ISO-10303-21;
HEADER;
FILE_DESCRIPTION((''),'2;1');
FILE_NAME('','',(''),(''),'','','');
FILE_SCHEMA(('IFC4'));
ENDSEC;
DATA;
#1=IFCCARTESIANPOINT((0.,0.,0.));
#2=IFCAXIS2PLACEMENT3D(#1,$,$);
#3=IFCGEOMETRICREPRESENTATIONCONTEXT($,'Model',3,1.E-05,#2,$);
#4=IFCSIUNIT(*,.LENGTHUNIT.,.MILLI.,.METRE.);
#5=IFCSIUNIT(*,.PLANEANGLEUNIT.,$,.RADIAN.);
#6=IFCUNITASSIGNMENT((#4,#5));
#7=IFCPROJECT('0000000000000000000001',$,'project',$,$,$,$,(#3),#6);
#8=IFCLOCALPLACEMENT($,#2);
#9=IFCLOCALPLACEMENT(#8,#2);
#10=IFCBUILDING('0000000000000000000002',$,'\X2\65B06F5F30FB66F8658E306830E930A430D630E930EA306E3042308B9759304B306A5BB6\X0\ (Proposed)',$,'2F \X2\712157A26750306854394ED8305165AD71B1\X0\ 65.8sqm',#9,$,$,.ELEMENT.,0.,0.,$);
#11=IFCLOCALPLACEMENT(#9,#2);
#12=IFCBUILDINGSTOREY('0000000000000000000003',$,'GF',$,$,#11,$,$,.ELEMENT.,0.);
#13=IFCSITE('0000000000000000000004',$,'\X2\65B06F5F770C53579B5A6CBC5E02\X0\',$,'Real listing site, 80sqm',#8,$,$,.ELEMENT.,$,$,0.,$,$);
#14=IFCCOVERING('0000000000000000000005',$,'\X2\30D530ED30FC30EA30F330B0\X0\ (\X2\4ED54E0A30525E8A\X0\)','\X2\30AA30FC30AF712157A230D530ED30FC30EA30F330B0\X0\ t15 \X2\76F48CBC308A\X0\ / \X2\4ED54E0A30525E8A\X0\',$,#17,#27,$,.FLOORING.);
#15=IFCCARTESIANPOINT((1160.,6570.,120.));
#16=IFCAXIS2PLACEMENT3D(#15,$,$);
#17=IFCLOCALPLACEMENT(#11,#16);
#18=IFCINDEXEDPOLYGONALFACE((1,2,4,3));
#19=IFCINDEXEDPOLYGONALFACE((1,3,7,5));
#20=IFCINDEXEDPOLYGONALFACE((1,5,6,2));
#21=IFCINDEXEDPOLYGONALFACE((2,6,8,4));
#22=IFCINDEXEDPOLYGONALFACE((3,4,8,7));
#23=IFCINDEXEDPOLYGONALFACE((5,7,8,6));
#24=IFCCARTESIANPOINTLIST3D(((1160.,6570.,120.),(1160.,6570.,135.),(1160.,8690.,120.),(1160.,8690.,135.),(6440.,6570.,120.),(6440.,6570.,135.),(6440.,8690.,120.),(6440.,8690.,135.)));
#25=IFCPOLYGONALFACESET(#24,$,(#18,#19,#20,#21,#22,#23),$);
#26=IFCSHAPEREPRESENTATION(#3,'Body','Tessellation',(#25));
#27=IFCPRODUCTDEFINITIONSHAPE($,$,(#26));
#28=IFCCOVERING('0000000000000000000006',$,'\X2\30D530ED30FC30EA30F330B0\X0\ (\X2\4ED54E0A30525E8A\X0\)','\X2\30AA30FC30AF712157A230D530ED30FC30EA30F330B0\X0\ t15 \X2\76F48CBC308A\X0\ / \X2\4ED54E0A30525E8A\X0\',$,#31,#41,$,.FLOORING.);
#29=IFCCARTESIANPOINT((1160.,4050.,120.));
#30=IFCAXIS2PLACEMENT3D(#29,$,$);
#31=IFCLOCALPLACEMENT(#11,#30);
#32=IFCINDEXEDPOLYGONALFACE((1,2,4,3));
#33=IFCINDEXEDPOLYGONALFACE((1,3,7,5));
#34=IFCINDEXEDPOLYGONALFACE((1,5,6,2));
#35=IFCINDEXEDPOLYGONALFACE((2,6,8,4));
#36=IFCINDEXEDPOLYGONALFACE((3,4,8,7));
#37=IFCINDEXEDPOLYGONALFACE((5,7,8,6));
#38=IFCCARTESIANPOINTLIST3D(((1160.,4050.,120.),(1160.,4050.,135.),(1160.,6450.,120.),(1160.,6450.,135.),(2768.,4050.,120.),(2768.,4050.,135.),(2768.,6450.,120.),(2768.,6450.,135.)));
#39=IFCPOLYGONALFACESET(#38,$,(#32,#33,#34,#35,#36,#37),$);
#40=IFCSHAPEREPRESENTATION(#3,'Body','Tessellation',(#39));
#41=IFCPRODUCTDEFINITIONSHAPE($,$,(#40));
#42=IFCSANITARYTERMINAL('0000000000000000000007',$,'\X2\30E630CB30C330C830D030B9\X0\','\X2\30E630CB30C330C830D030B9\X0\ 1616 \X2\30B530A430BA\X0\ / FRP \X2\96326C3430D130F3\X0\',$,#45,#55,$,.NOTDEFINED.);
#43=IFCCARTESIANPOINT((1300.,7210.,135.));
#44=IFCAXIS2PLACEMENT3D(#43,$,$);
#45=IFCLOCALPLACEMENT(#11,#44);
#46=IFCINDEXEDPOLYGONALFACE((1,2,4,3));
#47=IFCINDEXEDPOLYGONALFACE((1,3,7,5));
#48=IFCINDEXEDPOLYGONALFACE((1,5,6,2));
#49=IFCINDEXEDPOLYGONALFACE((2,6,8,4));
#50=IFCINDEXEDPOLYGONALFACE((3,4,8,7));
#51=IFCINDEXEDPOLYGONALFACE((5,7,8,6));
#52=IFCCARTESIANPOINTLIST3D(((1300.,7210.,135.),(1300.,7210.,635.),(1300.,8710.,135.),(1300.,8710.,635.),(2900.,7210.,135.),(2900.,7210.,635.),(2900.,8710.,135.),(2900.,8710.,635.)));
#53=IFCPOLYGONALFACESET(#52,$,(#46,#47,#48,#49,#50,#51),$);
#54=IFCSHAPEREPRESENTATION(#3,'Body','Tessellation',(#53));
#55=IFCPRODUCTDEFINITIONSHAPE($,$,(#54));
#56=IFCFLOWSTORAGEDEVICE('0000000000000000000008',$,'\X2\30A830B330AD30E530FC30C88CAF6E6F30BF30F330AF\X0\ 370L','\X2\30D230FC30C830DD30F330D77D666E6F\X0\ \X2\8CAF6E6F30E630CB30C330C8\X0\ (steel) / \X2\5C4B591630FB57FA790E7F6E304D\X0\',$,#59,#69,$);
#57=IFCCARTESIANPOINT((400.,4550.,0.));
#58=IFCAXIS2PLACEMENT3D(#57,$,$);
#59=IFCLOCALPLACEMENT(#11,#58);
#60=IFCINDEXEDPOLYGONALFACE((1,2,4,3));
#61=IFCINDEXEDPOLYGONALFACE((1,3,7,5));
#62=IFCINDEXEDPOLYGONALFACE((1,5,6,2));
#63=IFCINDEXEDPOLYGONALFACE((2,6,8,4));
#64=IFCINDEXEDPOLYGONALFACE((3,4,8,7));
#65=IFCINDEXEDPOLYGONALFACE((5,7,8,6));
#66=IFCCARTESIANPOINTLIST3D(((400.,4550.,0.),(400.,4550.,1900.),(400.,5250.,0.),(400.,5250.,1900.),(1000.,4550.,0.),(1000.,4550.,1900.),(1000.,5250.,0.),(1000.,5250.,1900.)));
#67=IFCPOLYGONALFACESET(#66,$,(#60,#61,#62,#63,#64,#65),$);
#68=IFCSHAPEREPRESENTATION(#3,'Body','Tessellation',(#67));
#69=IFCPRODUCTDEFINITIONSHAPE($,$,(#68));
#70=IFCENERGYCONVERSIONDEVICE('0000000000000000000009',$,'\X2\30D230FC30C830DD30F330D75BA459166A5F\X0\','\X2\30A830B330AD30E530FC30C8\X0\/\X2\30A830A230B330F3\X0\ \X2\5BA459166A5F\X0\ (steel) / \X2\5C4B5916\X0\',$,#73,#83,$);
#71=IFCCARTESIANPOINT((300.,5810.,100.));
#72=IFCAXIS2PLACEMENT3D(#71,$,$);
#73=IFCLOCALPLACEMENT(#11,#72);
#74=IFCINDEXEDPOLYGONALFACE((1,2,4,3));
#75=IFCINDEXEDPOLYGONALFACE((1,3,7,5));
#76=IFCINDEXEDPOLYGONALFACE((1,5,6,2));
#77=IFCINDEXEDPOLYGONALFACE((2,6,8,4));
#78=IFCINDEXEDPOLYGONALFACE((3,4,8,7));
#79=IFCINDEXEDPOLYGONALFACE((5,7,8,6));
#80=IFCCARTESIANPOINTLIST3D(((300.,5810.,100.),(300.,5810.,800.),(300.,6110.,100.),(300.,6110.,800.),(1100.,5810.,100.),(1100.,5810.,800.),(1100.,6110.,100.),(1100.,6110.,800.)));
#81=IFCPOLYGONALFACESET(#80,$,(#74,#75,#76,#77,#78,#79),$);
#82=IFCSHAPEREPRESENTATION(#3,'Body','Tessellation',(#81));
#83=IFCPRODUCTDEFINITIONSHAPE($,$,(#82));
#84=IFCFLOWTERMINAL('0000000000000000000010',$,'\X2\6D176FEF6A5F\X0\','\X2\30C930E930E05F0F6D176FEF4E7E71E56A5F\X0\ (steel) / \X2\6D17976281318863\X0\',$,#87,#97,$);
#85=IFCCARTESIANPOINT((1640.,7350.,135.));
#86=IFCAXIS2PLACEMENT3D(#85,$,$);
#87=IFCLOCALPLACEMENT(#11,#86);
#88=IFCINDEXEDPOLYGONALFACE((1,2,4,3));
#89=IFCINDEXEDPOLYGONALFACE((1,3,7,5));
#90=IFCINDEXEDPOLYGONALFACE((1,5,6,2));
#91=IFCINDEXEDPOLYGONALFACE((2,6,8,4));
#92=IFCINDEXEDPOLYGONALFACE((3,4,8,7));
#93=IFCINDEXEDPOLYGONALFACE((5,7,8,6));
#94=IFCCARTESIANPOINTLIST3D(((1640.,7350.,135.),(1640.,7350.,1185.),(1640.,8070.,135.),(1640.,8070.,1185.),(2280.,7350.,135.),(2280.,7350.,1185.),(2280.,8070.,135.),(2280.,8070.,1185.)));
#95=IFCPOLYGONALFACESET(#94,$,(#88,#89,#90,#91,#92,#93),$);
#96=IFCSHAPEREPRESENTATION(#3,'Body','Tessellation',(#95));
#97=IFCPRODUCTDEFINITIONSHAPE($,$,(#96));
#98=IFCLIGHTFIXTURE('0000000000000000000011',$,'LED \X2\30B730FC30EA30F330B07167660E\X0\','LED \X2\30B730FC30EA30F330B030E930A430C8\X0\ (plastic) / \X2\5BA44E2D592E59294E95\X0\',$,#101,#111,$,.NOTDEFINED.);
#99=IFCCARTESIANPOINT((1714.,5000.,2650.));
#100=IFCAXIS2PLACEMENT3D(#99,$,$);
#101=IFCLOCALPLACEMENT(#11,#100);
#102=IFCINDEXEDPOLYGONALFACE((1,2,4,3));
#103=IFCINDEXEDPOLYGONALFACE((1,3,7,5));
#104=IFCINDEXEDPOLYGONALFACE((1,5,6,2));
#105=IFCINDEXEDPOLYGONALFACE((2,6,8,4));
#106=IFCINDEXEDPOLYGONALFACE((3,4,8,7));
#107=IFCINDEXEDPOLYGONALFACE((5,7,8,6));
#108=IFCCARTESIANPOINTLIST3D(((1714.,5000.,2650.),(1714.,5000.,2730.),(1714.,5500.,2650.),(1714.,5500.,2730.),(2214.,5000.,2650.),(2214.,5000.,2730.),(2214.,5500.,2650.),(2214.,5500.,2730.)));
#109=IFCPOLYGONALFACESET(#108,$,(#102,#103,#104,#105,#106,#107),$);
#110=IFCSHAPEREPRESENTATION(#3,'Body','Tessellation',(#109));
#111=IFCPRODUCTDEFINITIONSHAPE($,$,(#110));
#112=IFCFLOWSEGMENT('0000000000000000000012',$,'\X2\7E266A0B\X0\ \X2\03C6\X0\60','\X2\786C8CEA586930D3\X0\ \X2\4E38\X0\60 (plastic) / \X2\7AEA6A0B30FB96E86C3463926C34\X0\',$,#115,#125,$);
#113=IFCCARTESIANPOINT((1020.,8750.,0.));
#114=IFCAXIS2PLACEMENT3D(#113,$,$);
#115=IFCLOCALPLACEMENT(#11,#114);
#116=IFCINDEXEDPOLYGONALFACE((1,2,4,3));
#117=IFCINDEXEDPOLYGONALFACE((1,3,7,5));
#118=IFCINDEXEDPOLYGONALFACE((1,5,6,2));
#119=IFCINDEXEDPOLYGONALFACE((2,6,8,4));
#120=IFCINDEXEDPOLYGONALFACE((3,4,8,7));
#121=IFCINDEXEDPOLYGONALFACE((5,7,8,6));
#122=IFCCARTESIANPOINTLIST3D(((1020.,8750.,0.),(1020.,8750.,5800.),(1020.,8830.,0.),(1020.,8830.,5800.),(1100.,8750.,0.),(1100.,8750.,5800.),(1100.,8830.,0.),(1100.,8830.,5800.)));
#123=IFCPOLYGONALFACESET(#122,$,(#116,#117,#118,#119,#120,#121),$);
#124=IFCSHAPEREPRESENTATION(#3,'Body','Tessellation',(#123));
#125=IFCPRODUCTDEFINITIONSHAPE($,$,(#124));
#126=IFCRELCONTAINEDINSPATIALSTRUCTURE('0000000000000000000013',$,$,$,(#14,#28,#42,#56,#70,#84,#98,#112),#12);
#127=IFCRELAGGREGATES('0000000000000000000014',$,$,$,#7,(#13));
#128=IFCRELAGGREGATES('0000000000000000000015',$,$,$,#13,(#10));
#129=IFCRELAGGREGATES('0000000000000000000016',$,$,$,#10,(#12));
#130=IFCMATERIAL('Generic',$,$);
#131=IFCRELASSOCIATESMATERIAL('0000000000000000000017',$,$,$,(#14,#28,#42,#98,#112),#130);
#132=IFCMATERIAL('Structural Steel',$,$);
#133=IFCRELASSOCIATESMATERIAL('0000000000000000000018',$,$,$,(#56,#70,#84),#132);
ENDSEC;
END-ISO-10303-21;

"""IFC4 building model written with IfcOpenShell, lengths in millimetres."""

from ifc_helpers import new_model, si_unit, frame, frame_2d, origin, place, context, project, spatial, rectangle, extrude, material, element, save


model = new_model("IFC4")

# Units and contexts
model_context = context("Model", 3, precision=1e-05, world=origin())
ifc_project = project(units=[si_unit("LENGTHUNIT", "METRE", prefix="MILLI"), si_unit("PLANEANGLEUNIT", "RADIAN")], contexts=[model_context])

# Site, building, storey
site_placement = place(None, origin())
site = spatial("IfcSite", under=ifc_project, at=site_placement, Name="新潟県南魚沼市", ObjectType="Real listing site, 80sqm", CompositionType="ELEMENT", RefElevation=0.0)
building_placement = place(site_placement, origin())
building = spatial("IfcBuilding", under=site, at=building_placement, Name="新潟・書斎とライブラリのある静かな家 (Proposed)", ObjectType="2F 無垢材と吹付け断熱 65.8sqm", CompositionType="ELEMENT", ElevationOfRefHeight=0.0, ElevationOfTerrain=0.0)
storey_placement = place(building_placement, origin())
storey = spatial("IfcBuildingStorey", under=building, at=storey_placement, Name="GF", CompositionType="ELEMENT", Elevation=0.0)

# Coverings
ifc_material_1 = material(Name="Generic")
covering_1_placement = place(storey_placement, frame((1160.0, 6570.0, 120.0)))
element("IfcCovering", 1, at=covering_1_placement, inside=storey, material=ifc_material_1, Name="フローリング (仕上げ床)", Description="オーク無垢フローリング t15 直貼り / 仕上げ床", PredefinedType="FLOORING", context=model_context, shape_type="SweptSolid", body=[
    extrude(rectangle(XDim=5280.0, YDim=2120.0, at=frame_2d((2640.0, 1060.0))), frame((1160.0, 6570.0, 120.0)), (0.0, 0.0, 1.0), 15.0),
])
covering_2_placement = place(storey_placement, frame((1160.0, 4050.0, 120.0)))
element("IfcCovering", 2, at=covering_2_placement, inside=storey, material=ifc_material_1, Name="フローリング (仕上げ床)", Description="オーク無垢フローリング t15 直貼り / 仕上げ床", PredefinedType="FLOORING", context=model_context, shape_type="SweptSolid", body=[
    extrude(rectangle(XDim=1608.0, YDim=2400.0, at=frame_2d((804.0, 1200.0))), frame((1160.0, 4050.0, 120.0)), (0.0, 0.0, 1.0), 15.0),
])

# Sanitary terminal
sanitary_terminal_placement = place(storey_placement, frame((1300.0, 7210.0, 135.0)))
element("IfcSanitaryTerminal", 3, at=sanitary_terminal_placement, inside=storey, material=ifc_material_1, Name="ユニットバス", Description="ユニットバス 1616 サイズ / FRP 防水パン", PredefinedType="NOTDEFINED", context=model_context, shape_type="SweptSolid", body=[
    extrude(rectangle(XDim=1600.0, YDim=1500.0, at=frame_2d((800.0, 750.0))), frame((1300.0, 7210.0, 135.0)), (0.0, 0.0, 1.0), 500.0),
])

# Flow storage device
ifc_material_2 = material(Name="Structural Steel")
flow_storage_device_placement = place(storey_placement, frame((400.0, 4550.0, 0.0)))
element("IfcFlowStorageDevice", 4, at=flow_storage_device_placement, inside=storey, material=ifc_material_2, Name="エコキュート貯湯タンク 370L", Description="ヒートポンプ給湯 貯湯ユニット (steel) / 屋外・基礎置き", context=model_context, shape_type="SweptSolid", body=[
    extrude(rectangle(XDim=600.0, YDim=700.0, at=frame_2d((300.0, 350.0))), frame((400.0, 4550.0, 0.0)), (0.0, 0.0, 1.0), 1900.0),
])

# Energy conversion device
energy_conversion_device_placement = place(storey_placement, frame((300.0, 5810.0, 100.0)))
element("IfcEnergyConversionDevice", 5, at=energy_conversion_device_placement, inside=storey, material=ifc_material_2, Name="ヒートポンプ室外機", Description="エコキュート/エアコン 室外機 (steel) / 屋外", context=model_context, shape_type="SweptSolid", body=[
    extrude(rectangle(XDim=800.0, YDim=300.0, at=frame_2d((400.0, 150.0))), frame((300.0, 5810.0, 100.0)), (0.0, 0.0, 1.0), 700.0),
])

# Flow terminal
flow_terminal_placement = place(storey_placement, frame((1640.0, 7350.0, 135.0)))
element("IfcFlowTerminal", 6, at=flow_terminal_placement, inside=storey, material=ifc_material_2, Name="洗濯機", Description="ドラム式洗濯乾燥機 (steel) / 洗面脱衣", context=model_context, shape_type="SweptSolid", body=[
    extrude(rectangle(XDim=640.0, YDim=720.0, at=frame_2d((320.0, 360.0))), frame((1640.0, 7350.0, 135.0)), (0.0, 0.0, 1.0), 1050.0),
])

# Light fixture
light_fixture_placement = place(storey_placement, frame((1714.0, 5000.0, 2650.0)))
element("IfcLightFixture", 7, at=light_fixture_placement, inside=storey, material=ifc_material_1, Name="LED シーリング照明", Description="LED シーリングライト (plastic) / 室中央天井", PredefinedType="NOTDEFINED", context=model_context, shape_type="SweptSolid", body=[
    extrude(rectangle(XDim=500.0, YDim=500.0, at=frame_2d((250.0, 250.0))), frame((1714.0, 5000.0, 2650.0)), (0.0, 0.0, 1.0), 80.0),
])

# Flow segment
flow_segment_placement = place(storey_placement, frame((1020.0, 8750.0, 0.0)))
element("IfcFlowSegment", 8, at=flow_segment_placement, inside=storey, material=ifc_material_1, Name="縦樋 φ60", Description="硬質塩ビ 丸60 (plastic) / 竪樋・雨水排水", context=model_context, shape_type="SweptSolid", body=[
    extrude(rectangle(XDim=80.0, YDim=80.0, at=frame_2d((40.0, 40.0))), frame((1020.0, 8750.0, 0.0)), (0.0, 0.0, 1.0), 5800.0),
])

save(model, "model.ifc")
